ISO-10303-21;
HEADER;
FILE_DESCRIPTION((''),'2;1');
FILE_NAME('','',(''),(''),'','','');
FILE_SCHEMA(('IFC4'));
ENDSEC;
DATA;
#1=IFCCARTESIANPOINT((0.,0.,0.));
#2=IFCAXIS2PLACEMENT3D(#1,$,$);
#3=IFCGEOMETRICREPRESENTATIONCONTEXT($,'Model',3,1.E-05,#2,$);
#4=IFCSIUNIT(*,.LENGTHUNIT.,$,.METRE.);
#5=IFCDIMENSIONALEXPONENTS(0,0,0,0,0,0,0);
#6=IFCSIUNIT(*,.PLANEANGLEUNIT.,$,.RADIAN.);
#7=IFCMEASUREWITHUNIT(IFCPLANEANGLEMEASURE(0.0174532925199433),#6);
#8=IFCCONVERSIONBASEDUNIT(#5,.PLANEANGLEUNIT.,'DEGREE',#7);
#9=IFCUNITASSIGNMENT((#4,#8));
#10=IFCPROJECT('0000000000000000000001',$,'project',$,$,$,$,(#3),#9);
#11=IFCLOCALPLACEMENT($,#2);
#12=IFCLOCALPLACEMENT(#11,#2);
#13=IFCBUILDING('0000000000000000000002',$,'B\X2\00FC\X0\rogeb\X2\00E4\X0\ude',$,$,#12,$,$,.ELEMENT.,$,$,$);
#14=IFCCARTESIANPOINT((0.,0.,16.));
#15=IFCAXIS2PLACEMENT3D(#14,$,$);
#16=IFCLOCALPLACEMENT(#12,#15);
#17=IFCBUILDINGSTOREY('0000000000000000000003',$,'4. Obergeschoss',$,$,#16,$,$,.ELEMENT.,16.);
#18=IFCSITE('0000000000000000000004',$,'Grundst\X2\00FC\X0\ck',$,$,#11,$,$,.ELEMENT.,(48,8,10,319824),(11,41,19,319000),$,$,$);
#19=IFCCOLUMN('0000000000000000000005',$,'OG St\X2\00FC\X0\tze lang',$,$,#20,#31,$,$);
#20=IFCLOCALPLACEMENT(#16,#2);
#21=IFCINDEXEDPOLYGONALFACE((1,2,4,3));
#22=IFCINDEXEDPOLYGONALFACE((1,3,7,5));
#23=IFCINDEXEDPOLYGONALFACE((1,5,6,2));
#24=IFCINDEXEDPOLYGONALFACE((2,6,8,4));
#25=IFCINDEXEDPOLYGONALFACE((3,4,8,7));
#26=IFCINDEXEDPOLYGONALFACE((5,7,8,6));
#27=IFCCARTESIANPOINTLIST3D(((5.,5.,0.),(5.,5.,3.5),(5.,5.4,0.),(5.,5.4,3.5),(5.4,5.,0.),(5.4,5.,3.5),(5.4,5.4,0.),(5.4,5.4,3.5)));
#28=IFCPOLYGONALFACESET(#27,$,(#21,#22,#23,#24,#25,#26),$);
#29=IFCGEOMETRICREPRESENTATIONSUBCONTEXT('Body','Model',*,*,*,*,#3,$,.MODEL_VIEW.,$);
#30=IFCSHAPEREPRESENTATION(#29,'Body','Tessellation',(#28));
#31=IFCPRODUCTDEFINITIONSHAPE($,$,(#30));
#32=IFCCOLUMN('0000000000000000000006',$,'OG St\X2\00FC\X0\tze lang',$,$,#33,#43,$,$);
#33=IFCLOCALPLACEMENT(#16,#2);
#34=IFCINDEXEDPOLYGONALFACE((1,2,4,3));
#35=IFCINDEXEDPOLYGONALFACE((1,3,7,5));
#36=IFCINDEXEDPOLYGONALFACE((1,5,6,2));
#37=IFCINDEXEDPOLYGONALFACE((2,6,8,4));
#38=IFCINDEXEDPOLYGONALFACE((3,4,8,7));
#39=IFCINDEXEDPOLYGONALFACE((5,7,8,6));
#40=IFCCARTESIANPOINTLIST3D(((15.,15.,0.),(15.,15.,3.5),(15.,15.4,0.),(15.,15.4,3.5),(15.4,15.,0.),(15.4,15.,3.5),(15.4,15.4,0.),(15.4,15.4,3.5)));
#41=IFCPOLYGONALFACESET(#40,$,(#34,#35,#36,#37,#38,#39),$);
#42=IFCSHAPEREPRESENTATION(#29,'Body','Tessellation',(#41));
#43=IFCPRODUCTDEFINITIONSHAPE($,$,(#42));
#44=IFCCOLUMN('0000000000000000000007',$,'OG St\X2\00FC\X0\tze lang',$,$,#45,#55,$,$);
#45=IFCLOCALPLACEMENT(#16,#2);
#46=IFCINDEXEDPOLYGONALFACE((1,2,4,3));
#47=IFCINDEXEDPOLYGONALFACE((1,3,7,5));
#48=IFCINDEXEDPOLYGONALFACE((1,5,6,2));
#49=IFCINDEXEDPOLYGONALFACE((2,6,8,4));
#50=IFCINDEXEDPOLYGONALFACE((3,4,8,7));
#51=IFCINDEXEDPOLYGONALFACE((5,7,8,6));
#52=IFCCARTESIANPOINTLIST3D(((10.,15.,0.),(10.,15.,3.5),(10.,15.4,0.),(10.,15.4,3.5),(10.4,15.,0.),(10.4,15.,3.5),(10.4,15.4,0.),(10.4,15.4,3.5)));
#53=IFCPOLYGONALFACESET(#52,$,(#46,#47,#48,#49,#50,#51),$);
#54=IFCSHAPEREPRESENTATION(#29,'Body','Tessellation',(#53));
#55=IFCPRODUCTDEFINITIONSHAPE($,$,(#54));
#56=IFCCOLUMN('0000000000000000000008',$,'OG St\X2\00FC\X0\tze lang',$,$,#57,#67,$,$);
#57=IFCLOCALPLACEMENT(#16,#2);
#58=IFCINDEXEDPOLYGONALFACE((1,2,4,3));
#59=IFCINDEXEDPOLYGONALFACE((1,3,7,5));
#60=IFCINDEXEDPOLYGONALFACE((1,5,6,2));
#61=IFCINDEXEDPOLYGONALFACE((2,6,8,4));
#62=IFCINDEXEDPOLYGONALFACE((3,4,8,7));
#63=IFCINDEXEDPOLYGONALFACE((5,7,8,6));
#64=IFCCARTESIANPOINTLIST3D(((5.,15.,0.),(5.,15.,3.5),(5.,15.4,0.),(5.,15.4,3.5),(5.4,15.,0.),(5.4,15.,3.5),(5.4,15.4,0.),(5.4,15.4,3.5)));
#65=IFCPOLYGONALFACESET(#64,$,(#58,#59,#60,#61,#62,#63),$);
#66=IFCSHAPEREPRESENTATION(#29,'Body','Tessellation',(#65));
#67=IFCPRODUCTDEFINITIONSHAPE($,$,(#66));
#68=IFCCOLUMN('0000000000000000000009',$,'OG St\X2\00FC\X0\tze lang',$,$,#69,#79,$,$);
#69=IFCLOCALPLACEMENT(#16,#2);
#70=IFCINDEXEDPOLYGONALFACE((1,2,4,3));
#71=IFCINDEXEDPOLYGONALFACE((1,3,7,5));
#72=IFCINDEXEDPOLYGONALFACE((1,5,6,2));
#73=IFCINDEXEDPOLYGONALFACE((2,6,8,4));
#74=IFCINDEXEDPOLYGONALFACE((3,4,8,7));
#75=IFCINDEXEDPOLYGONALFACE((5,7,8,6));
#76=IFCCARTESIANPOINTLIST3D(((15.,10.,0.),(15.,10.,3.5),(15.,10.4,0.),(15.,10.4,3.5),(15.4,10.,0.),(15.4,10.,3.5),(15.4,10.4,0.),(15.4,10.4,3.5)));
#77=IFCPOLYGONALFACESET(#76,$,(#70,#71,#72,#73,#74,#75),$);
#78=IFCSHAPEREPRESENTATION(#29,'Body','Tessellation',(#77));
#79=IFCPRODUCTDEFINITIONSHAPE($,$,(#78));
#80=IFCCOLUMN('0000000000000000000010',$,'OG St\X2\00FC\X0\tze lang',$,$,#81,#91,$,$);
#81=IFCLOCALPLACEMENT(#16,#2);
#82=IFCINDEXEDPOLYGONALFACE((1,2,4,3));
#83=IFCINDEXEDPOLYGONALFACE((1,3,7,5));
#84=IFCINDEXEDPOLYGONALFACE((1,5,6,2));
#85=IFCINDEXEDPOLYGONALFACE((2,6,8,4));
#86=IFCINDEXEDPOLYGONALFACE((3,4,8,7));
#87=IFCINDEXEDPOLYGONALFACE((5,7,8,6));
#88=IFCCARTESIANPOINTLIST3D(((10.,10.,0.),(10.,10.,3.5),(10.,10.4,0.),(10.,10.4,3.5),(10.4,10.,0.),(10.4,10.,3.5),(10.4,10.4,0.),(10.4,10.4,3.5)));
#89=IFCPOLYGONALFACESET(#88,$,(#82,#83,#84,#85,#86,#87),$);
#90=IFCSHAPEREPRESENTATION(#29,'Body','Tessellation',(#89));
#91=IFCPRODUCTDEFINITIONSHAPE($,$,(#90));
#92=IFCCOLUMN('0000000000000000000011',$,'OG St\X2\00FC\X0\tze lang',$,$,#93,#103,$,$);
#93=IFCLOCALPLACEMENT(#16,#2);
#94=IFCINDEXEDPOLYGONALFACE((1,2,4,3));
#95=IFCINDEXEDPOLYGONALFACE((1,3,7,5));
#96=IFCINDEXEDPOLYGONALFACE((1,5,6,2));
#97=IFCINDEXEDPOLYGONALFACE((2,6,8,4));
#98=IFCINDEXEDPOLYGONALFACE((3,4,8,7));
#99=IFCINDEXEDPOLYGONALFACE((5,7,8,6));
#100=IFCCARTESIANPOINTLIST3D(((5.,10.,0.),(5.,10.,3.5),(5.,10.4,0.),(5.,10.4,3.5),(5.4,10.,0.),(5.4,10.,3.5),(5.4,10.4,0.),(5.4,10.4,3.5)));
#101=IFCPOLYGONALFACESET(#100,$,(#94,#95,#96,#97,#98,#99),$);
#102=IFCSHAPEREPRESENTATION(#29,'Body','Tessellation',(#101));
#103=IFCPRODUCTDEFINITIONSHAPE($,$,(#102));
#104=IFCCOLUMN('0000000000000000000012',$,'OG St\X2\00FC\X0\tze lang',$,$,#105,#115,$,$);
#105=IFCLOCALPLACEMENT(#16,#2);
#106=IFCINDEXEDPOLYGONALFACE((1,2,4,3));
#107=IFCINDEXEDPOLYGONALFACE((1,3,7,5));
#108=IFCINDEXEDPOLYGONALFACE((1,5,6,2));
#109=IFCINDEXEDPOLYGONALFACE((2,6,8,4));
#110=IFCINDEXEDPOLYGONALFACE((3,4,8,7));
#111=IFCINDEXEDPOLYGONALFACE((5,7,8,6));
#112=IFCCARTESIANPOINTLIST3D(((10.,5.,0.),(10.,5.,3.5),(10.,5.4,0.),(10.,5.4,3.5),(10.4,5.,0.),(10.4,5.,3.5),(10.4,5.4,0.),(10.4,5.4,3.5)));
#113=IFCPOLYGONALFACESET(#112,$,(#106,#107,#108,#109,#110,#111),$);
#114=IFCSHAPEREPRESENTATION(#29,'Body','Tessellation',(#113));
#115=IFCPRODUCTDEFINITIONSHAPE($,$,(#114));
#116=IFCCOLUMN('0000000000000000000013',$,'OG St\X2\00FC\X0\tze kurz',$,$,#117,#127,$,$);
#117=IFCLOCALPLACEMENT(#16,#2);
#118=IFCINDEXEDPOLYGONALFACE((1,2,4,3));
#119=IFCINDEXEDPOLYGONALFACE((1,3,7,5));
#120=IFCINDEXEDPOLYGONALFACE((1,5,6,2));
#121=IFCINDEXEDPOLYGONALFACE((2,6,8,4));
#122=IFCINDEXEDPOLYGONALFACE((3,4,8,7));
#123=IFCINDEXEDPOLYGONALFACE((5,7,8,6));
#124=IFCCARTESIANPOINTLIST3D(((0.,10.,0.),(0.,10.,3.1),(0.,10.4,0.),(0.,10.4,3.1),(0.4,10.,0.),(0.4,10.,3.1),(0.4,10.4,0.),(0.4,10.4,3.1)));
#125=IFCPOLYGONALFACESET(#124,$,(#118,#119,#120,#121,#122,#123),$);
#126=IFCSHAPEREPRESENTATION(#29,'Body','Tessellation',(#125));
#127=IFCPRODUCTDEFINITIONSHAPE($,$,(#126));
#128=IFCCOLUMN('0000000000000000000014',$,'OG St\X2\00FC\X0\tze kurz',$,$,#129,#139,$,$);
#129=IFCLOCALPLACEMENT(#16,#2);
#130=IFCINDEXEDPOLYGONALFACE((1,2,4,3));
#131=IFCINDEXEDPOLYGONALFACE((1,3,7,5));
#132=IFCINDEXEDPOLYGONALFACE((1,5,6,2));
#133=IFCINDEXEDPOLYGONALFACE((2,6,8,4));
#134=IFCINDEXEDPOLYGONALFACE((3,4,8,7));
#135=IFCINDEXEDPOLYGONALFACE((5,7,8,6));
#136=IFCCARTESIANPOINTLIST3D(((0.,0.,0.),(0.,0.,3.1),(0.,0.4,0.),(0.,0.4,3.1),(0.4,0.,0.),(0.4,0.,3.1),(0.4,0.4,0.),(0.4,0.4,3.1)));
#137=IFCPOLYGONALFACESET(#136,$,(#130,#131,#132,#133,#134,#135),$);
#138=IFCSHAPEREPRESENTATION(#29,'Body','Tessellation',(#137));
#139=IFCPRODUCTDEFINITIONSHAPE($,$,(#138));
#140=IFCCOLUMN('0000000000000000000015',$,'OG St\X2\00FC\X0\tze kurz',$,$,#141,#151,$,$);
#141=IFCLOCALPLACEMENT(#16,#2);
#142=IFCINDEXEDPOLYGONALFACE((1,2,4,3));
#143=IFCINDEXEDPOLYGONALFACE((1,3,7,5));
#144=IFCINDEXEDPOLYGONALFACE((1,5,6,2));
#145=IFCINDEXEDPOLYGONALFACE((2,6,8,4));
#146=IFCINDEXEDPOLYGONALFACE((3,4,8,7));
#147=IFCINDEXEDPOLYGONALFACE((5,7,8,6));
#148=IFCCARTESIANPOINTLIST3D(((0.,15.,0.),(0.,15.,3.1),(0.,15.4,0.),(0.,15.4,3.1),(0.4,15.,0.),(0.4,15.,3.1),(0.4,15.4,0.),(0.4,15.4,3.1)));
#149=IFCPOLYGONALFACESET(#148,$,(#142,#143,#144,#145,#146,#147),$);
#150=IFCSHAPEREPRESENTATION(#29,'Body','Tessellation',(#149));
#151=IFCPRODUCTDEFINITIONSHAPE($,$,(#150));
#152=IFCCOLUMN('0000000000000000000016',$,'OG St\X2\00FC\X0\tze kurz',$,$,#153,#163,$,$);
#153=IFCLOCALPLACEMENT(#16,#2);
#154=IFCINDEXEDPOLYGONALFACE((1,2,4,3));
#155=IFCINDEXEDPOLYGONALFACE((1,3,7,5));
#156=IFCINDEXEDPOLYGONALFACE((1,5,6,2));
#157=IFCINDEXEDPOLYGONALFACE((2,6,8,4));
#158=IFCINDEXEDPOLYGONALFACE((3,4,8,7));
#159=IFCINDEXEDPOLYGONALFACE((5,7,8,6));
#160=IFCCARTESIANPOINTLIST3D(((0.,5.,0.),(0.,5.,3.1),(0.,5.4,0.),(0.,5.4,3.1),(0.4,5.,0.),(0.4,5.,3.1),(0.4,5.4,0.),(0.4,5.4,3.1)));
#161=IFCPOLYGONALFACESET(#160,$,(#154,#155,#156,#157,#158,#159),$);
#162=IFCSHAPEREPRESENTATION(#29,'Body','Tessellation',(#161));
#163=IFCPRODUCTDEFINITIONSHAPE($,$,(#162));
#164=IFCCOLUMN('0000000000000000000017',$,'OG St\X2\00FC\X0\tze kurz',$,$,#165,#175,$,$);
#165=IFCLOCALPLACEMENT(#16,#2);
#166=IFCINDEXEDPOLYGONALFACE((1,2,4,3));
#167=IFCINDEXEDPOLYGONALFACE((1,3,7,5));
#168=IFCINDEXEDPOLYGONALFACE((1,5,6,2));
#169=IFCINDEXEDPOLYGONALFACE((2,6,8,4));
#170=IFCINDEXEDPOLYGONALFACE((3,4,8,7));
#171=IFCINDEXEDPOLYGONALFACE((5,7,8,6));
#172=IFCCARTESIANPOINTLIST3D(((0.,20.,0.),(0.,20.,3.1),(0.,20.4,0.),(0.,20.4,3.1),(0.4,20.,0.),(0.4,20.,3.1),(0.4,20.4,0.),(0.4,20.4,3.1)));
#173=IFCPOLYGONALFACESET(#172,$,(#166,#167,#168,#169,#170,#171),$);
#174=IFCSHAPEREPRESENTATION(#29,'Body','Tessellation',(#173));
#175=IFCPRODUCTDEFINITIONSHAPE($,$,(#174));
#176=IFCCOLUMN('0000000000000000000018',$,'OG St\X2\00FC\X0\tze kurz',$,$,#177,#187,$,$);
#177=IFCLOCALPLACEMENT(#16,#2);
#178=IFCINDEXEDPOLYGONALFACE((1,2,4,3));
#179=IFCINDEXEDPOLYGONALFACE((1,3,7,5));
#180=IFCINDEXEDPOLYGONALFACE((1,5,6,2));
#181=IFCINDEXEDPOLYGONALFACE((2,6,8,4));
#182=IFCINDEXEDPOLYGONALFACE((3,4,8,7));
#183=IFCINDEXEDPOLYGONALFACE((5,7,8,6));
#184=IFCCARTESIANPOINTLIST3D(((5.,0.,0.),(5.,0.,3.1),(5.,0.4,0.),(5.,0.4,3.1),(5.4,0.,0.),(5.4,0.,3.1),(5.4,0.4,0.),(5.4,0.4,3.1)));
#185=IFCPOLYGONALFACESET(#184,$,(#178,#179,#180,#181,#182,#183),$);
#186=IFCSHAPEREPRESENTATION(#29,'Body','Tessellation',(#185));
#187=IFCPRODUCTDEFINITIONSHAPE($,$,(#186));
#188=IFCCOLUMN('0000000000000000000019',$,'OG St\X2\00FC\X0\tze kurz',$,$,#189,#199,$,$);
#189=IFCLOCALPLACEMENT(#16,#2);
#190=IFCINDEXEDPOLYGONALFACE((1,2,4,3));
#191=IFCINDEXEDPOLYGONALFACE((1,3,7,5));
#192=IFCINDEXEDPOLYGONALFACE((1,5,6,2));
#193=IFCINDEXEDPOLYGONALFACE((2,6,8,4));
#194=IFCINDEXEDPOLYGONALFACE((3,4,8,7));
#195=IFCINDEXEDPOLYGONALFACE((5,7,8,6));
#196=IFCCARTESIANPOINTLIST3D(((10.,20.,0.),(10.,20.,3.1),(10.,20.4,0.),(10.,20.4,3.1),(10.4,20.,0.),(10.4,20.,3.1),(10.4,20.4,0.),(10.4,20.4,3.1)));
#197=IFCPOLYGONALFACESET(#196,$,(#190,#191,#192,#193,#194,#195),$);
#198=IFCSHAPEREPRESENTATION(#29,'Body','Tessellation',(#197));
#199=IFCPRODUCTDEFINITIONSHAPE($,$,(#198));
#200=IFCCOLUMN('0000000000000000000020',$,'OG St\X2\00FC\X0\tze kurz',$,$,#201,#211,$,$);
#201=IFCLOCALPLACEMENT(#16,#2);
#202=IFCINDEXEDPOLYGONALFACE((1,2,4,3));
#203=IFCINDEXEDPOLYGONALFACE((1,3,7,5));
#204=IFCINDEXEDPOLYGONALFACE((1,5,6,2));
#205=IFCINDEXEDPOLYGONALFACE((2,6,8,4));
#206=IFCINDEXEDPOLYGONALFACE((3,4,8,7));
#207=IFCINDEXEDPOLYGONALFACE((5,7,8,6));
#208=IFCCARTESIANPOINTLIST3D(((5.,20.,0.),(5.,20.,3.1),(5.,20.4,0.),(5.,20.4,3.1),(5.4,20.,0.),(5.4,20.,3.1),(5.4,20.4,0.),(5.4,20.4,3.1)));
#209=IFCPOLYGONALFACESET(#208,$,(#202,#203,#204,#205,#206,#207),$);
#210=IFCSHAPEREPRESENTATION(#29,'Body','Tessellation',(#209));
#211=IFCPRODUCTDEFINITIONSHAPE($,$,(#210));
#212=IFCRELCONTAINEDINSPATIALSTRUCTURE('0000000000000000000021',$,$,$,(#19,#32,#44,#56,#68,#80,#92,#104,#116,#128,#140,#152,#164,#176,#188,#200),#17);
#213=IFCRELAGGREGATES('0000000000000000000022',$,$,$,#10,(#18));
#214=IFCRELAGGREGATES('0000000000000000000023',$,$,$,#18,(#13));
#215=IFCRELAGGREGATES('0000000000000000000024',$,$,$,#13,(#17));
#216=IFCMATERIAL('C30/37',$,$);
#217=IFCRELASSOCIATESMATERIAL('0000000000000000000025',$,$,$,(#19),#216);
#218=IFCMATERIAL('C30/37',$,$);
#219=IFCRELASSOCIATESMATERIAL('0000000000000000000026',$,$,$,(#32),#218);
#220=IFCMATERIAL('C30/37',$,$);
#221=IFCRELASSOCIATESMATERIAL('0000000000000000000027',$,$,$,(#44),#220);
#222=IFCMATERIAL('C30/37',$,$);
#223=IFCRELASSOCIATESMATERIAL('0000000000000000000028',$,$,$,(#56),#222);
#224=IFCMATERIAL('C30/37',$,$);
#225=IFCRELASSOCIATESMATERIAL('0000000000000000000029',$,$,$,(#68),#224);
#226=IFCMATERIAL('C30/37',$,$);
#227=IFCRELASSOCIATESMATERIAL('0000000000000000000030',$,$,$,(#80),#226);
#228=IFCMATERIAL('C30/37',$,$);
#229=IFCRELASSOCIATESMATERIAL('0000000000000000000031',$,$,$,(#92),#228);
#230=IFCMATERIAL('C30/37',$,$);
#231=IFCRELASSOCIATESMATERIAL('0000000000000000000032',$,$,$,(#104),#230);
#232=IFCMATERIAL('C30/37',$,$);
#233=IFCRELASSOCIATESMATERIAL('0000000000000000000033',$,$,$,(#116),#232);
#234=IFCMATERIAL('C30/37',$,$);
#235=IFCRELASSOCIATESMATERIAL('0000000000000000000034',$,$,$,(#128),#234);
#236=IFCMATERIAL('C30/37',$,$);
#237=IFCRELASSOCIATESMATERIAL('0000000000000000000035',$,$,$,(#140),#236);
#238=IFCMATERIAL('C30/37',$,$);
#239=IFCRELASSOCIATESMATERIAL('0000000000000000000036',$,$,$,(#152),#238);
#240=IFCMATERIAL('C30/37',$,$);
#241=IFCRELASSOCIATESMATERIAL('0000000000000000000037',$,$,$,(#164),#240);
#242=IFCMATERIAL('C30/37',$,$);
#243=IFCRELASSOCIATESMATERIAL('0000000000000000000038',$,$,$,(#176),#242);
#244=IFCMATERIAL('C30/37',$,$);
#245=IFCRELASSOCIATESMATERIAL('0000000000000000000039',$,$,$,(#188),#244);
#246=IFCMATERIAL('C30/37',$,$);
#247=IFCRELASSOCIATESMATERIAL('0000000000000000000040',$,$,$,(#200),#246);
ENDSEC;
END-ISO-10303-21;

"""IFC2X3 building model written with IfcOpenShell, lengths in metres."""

from ifc_helpers import new_model, entity, si_unit, converted_unit, frame, frame_2d, origin, origin_with_axes, place, context, subcontext, project, spatial, rectangle, extrude, material, element, save


model = new_model("IFC2X3")

# Units and contexts
model_context = context("Model", 3, precision=1e-05, world=origin())
body_context = subcontext(model_context, "Body", "Model", "MODEL_VIEW")
ifc_project = project(units=[si_unit("LENGTHUNIT", "METRE"), converted_unit("PLANEANGLEUNIT", "DEGREE", entity("IfcPlaneAngleMeasure", 0.0174532925199433), si_unit("PLANEANGLEUNIT", "RADIAN"), dimensions=[0, 0, 0, 0, 0, 0, 0])], contexts=[model_context])

# Site, building, storey
site_placement = place(None, origin())
site = spatial("IfcSite", under=ifc_project, at=site_placement, Name="Grundstück", CompositionType="ELEMENT", RefLatitude=(48, 8, 10, 319824), RefLongitude=(11, 41, 19, 319000))
building_placement = place(site_placement, origin())
building = spatial("IfcBuilding", under=site, at=building_placement, Name="Bürogebäude", CompositionType="ELEMENT")
storey_placement = place(building_placement, frame((0.0, 0.0, 16.0)))
storey = spatial("IfcBuildingStorey", under=building, at=storey_placement, Name="4. Obergeschoss", CompositionType="ELEMENT", Elevation=16.0)

# Columns
ifc_material_1 = material(Name="C30/37")
column_1_placement = place(storey_placement, frame((5.0, 5.0, 0.0)))
element("IfcColumn", 1, at=column_1_placement, inside=storey, material=ifc_material_1, Name="OG Stütze lang", context=body_context, shape_type="SweptSolid", body=[
    extrude(rectangle(XDim=0.4, YDim=0.4, at=frame_2d((0.2, 0.2), x_axis=(1.0, 0.0))), origin_with_axes(), (0.0, 0.0, 1.0), 3.5),
])
ifc_material_2 = material(Name="C30/37")
column_2_placement = place(storey_placement, frame((15.0, 15.0, 0.0)))
element("IfcColumn", 2, at=column_2_placement, inside=storey, material=ifc_material_2, Name="OG Stütze lang", context=body_context, shape_type="SweptSolid", body=[
    extrude(rectangle(XDim=0.4, YDim=0.4, at=frame_2d((0.2, 0.2), x_axis=(1.0, 0.0))), origin_with_axes(), (0.0, 0.0, 1.0), 3.5),
])
ifc_material_3 = material(Name="C30/37")
column_3_placement = place(storey_placement, frame((10.0, 15.0, 0.0)))
element("IfcColumn", 3, at=column_3_placement, inside=storey, material=ifc_material_3, Name="OG Stütze lang", context=body_context, shape_type="SweptSolid", body=[
    extrude(rectangle(XDim=0.4, YDim=0.4, at=frame_2d((0.2, 0.2), x_axis=(1.0, 0.0))), origin_with_axes(), (0.0, 0.0, 1.0), 3.5),
])
ifc_material_4 = material(Name="C30/37")
column_4_placement = place(storey_placement, frame((5.0, 15.0, 0.0)))
element("IfcColumn", 4, at=column_4_placement, inside=storey, material=ifc_material_4, Name="OG Stütze lang", context=body_context, shape_type="SweptSolid", body=[
    extrude(rectangle(XDim=0.4, YDim=0.4, at=frame_2d((0.2, 0.2), x_axis=(1.0, 0.0))), origin_with_axes(), (0.0, 0.0, 1.0), 3.5),
])
ifc_material_5 = material(Name="C30/37")
column_5_placement = place(storey_placement, frame((15.0, 10.0, 0.0)))
element("IfcColumn", 5, at=column_5_placement, inside=storey, material=ifc_material_5, Name="OG Stütze lang", context=body_context, shape_type="SweptSolid", body=[
    extrude(rectangle(XDim=0.4, YDim=0.4, at=frame_2d((0.2, 0.2), x_axis=(1.0, 0.0))), origin_with_axes(), (0.0, 0.0, 1.0), 3.5),
])
ifc_material_6 = material(Name="C30/37")
column_6_placement = place(storey_placement, frame((10.0, 10.0, 0.0)))
element("IfcColumn", 6, at=column_6_placement, inside=storey, material=ifc_material_6, Name="OG Stütze lang", context=body_context, shape_type="SweptSolid", body=[
    extrude(rectangle(XDim=0.4, YDim=0.4, at=frame_2d((0.2, 0.2), x_axis=(1.0, 0.0))), origin_with_axes(), (0.0, 0.0, 1.0), 3.5),
])
ifc_material_7 = material(Name="C30/37")
column_7_placement = place(storey_placement, frame((5.0, 10.0, 0.0)))
element("IfcColumn", 7, at=column_7_placement, inside=storey, material=ifc_material_7, Name="OG Stütze lang", context=body_context, shape_type="SweptSolid", body=[
    extrude(rectangle(XDim=0.4, YDim=0.4, at=frame_2d((0.2, 0.2), x_axis=(1.0, 0.0))), origin_with_axes(), (0.0, 0.0, 1.0), 3.5),
])
ifc_material_8 = material(Name="C30/37")
column_8_placement = place(storey_placement, frame((10.0, 5.0, 0.0)))
element("IfcColumn", 8, at=column_8_placement, inside=storey, material=ifc_material_8, Name="OG Stütze lang", context=body_context, shape_type="SweptSolid", body=[
    extrude(rectangle(XDim=0.4, YDim=0.4, at=frame_2d((0.2, 0.2), x_axis=(1.0, 0.0))), origin_with_axes(), (0.0, 0.0, 1.0), 3.5),
])
ifc_material_9 = material(Name="C30/37")
column_9_placement = place(storey_placement, frame((0.0, 10.0, 0.0)))
element("IfcColumn", 9, at=column_9_placement, inside=storey, material=ifc_material_9, Name="OG Stütze kurz", context=body_context, shape_type="SweptSolid", body=[
    extrude(rectangle(XDim=0.4, YDim=0.4, at=frame_2d((0.2, 0.2), x_axis=(1.0, 0.0))), origin_with_axes(), (0.0, 0.0, 1.0), 3.1),
])
ifc_material_10 = material(Name="C30/37")
column_10_placement = place(storey_placement, origin())
element("IfcColumn", 10, at=column_10_placement, inside=storey, material=ifc_material_10, Name="OG Stütze kurz", context=body_context, shape_type="SweptSolid", body=[
    extrude(rectangle(XDim=0.4, YDim=0.4, at=frame_2d((0.2, 0.2), x_axis=(1.0, 0.0))), origin_with_axes(), (0.0, 0.0, 1.0), 3.1),
])
ifc_material_11 = material(Name="C30/37")
column_11_placement = place(storey_placement, frame((0.0, 15.0, 0.0)))
element("IfcColumn", 11, at=column_11_placement, inside=storey, material=ifc_material_11, Name="OG Stütze kurz", context=body_context, shape_type="SweptSolid", body=[
    extrude(rectangle(XDim=0.4, YDim=0.4, at=frame_2d((0.2, 0.2), x_axis=(1.0, 0.0))), origin_with_axes(), (0.0, 0.0, 1.0), 3.1),
])
ifc_material_12 = material(Name="C30/37")
column_12_placement = place(storey_placement, frame((0.0, 5.0, 0.0)))
element("IfcColumn", 12, at=column_12_placement, inside=storey, material=ifc_material_12, Name="OG Stütze kurz", context=body_context, shape_type="SweptSolid", body=[
    extrude(rectangle(XDim=0.4, YDim=0.4, at=frame_2d((0.2, 0.2), x_axis=(1.0, 0.0))), origin_with_axes(), (0.0, 0.0, 1.0), 3.1),
])
ifc_material_13 = material(Name="C30/37")
column_13_placement = place(storey_placement, frame((0.0, 20.0, 0.0)))
element("IfcColumn", 13, at=column_13_placement, inside=storey, material=ifc_material_13, Name="OG Stütze kurz", context=body_context, shape_type="SweptSolid", body=[
    extrude(rectangle(XDim=0.4, YDim=0.4, at=frame_2d((0.2, 0.2), x_axis=(1.0, 0.0))), origin_with_axes(), (0.0, 0.0, 1.0), 3.1),
])
ifc_material_14 = material(Name="C30/37")
column_14_placement = place(storey_placement, frame((5.0, 0.0, 0.0)))
element("IfcColumn", 14, at=column_14_placement, inside=storey, material=ifc_material_14, Name="OG Stütze kurz", context=body_context, shape_type="SweptSolid", body=[
    extrude(rectangle(XDim=0.4, YDim=0.4, at=frame_2d((0.2, 0.2), x_axis=(1.0, 0.0))), origin_with_axes(), (0.0, 0.0, 1.0), 3.1),
])
ifc_material_15 = material(Name="C30/37")
column_15_placement = place(storey_placement, frame((10.0, 20.0, 0.0)))
element("IfcColumn", 15, at=column_15_placement, inside=storey, material=ifc_material_15, Name="OG Stütze kurz", context=body_context, shape_type="SweptSolid", body=[
    extrude(rectangle(XDim=0.4, YDim=0.4, at=frame_2d((0.2, 0.2), x_axis=(1.0, 0.0))), origin_with_axes(), (0.0, 0.0, 1.0), 3.1),
])
ifc_material_16 = material(Name="C30/37")
column_16_placement = place(storey_placement, frame((5.0, 20.0, 0.0)))
element("IfcColumn", 16, at=column_16_placement, inside=storey, material=ifc_material_16, Name="OG Stütze kurz", context=body_context, shape_type="SweptSolid", body=[
    extrude(rectangle(XDim=0.4, YDim=0.4, at=frame_2d((0.2, 0.2), x_axis=(1.0, 0.0))), origin_with_axes(), (0.0, 0.0, 1.0), 3.1),
])

save(model, "model.ifc")
